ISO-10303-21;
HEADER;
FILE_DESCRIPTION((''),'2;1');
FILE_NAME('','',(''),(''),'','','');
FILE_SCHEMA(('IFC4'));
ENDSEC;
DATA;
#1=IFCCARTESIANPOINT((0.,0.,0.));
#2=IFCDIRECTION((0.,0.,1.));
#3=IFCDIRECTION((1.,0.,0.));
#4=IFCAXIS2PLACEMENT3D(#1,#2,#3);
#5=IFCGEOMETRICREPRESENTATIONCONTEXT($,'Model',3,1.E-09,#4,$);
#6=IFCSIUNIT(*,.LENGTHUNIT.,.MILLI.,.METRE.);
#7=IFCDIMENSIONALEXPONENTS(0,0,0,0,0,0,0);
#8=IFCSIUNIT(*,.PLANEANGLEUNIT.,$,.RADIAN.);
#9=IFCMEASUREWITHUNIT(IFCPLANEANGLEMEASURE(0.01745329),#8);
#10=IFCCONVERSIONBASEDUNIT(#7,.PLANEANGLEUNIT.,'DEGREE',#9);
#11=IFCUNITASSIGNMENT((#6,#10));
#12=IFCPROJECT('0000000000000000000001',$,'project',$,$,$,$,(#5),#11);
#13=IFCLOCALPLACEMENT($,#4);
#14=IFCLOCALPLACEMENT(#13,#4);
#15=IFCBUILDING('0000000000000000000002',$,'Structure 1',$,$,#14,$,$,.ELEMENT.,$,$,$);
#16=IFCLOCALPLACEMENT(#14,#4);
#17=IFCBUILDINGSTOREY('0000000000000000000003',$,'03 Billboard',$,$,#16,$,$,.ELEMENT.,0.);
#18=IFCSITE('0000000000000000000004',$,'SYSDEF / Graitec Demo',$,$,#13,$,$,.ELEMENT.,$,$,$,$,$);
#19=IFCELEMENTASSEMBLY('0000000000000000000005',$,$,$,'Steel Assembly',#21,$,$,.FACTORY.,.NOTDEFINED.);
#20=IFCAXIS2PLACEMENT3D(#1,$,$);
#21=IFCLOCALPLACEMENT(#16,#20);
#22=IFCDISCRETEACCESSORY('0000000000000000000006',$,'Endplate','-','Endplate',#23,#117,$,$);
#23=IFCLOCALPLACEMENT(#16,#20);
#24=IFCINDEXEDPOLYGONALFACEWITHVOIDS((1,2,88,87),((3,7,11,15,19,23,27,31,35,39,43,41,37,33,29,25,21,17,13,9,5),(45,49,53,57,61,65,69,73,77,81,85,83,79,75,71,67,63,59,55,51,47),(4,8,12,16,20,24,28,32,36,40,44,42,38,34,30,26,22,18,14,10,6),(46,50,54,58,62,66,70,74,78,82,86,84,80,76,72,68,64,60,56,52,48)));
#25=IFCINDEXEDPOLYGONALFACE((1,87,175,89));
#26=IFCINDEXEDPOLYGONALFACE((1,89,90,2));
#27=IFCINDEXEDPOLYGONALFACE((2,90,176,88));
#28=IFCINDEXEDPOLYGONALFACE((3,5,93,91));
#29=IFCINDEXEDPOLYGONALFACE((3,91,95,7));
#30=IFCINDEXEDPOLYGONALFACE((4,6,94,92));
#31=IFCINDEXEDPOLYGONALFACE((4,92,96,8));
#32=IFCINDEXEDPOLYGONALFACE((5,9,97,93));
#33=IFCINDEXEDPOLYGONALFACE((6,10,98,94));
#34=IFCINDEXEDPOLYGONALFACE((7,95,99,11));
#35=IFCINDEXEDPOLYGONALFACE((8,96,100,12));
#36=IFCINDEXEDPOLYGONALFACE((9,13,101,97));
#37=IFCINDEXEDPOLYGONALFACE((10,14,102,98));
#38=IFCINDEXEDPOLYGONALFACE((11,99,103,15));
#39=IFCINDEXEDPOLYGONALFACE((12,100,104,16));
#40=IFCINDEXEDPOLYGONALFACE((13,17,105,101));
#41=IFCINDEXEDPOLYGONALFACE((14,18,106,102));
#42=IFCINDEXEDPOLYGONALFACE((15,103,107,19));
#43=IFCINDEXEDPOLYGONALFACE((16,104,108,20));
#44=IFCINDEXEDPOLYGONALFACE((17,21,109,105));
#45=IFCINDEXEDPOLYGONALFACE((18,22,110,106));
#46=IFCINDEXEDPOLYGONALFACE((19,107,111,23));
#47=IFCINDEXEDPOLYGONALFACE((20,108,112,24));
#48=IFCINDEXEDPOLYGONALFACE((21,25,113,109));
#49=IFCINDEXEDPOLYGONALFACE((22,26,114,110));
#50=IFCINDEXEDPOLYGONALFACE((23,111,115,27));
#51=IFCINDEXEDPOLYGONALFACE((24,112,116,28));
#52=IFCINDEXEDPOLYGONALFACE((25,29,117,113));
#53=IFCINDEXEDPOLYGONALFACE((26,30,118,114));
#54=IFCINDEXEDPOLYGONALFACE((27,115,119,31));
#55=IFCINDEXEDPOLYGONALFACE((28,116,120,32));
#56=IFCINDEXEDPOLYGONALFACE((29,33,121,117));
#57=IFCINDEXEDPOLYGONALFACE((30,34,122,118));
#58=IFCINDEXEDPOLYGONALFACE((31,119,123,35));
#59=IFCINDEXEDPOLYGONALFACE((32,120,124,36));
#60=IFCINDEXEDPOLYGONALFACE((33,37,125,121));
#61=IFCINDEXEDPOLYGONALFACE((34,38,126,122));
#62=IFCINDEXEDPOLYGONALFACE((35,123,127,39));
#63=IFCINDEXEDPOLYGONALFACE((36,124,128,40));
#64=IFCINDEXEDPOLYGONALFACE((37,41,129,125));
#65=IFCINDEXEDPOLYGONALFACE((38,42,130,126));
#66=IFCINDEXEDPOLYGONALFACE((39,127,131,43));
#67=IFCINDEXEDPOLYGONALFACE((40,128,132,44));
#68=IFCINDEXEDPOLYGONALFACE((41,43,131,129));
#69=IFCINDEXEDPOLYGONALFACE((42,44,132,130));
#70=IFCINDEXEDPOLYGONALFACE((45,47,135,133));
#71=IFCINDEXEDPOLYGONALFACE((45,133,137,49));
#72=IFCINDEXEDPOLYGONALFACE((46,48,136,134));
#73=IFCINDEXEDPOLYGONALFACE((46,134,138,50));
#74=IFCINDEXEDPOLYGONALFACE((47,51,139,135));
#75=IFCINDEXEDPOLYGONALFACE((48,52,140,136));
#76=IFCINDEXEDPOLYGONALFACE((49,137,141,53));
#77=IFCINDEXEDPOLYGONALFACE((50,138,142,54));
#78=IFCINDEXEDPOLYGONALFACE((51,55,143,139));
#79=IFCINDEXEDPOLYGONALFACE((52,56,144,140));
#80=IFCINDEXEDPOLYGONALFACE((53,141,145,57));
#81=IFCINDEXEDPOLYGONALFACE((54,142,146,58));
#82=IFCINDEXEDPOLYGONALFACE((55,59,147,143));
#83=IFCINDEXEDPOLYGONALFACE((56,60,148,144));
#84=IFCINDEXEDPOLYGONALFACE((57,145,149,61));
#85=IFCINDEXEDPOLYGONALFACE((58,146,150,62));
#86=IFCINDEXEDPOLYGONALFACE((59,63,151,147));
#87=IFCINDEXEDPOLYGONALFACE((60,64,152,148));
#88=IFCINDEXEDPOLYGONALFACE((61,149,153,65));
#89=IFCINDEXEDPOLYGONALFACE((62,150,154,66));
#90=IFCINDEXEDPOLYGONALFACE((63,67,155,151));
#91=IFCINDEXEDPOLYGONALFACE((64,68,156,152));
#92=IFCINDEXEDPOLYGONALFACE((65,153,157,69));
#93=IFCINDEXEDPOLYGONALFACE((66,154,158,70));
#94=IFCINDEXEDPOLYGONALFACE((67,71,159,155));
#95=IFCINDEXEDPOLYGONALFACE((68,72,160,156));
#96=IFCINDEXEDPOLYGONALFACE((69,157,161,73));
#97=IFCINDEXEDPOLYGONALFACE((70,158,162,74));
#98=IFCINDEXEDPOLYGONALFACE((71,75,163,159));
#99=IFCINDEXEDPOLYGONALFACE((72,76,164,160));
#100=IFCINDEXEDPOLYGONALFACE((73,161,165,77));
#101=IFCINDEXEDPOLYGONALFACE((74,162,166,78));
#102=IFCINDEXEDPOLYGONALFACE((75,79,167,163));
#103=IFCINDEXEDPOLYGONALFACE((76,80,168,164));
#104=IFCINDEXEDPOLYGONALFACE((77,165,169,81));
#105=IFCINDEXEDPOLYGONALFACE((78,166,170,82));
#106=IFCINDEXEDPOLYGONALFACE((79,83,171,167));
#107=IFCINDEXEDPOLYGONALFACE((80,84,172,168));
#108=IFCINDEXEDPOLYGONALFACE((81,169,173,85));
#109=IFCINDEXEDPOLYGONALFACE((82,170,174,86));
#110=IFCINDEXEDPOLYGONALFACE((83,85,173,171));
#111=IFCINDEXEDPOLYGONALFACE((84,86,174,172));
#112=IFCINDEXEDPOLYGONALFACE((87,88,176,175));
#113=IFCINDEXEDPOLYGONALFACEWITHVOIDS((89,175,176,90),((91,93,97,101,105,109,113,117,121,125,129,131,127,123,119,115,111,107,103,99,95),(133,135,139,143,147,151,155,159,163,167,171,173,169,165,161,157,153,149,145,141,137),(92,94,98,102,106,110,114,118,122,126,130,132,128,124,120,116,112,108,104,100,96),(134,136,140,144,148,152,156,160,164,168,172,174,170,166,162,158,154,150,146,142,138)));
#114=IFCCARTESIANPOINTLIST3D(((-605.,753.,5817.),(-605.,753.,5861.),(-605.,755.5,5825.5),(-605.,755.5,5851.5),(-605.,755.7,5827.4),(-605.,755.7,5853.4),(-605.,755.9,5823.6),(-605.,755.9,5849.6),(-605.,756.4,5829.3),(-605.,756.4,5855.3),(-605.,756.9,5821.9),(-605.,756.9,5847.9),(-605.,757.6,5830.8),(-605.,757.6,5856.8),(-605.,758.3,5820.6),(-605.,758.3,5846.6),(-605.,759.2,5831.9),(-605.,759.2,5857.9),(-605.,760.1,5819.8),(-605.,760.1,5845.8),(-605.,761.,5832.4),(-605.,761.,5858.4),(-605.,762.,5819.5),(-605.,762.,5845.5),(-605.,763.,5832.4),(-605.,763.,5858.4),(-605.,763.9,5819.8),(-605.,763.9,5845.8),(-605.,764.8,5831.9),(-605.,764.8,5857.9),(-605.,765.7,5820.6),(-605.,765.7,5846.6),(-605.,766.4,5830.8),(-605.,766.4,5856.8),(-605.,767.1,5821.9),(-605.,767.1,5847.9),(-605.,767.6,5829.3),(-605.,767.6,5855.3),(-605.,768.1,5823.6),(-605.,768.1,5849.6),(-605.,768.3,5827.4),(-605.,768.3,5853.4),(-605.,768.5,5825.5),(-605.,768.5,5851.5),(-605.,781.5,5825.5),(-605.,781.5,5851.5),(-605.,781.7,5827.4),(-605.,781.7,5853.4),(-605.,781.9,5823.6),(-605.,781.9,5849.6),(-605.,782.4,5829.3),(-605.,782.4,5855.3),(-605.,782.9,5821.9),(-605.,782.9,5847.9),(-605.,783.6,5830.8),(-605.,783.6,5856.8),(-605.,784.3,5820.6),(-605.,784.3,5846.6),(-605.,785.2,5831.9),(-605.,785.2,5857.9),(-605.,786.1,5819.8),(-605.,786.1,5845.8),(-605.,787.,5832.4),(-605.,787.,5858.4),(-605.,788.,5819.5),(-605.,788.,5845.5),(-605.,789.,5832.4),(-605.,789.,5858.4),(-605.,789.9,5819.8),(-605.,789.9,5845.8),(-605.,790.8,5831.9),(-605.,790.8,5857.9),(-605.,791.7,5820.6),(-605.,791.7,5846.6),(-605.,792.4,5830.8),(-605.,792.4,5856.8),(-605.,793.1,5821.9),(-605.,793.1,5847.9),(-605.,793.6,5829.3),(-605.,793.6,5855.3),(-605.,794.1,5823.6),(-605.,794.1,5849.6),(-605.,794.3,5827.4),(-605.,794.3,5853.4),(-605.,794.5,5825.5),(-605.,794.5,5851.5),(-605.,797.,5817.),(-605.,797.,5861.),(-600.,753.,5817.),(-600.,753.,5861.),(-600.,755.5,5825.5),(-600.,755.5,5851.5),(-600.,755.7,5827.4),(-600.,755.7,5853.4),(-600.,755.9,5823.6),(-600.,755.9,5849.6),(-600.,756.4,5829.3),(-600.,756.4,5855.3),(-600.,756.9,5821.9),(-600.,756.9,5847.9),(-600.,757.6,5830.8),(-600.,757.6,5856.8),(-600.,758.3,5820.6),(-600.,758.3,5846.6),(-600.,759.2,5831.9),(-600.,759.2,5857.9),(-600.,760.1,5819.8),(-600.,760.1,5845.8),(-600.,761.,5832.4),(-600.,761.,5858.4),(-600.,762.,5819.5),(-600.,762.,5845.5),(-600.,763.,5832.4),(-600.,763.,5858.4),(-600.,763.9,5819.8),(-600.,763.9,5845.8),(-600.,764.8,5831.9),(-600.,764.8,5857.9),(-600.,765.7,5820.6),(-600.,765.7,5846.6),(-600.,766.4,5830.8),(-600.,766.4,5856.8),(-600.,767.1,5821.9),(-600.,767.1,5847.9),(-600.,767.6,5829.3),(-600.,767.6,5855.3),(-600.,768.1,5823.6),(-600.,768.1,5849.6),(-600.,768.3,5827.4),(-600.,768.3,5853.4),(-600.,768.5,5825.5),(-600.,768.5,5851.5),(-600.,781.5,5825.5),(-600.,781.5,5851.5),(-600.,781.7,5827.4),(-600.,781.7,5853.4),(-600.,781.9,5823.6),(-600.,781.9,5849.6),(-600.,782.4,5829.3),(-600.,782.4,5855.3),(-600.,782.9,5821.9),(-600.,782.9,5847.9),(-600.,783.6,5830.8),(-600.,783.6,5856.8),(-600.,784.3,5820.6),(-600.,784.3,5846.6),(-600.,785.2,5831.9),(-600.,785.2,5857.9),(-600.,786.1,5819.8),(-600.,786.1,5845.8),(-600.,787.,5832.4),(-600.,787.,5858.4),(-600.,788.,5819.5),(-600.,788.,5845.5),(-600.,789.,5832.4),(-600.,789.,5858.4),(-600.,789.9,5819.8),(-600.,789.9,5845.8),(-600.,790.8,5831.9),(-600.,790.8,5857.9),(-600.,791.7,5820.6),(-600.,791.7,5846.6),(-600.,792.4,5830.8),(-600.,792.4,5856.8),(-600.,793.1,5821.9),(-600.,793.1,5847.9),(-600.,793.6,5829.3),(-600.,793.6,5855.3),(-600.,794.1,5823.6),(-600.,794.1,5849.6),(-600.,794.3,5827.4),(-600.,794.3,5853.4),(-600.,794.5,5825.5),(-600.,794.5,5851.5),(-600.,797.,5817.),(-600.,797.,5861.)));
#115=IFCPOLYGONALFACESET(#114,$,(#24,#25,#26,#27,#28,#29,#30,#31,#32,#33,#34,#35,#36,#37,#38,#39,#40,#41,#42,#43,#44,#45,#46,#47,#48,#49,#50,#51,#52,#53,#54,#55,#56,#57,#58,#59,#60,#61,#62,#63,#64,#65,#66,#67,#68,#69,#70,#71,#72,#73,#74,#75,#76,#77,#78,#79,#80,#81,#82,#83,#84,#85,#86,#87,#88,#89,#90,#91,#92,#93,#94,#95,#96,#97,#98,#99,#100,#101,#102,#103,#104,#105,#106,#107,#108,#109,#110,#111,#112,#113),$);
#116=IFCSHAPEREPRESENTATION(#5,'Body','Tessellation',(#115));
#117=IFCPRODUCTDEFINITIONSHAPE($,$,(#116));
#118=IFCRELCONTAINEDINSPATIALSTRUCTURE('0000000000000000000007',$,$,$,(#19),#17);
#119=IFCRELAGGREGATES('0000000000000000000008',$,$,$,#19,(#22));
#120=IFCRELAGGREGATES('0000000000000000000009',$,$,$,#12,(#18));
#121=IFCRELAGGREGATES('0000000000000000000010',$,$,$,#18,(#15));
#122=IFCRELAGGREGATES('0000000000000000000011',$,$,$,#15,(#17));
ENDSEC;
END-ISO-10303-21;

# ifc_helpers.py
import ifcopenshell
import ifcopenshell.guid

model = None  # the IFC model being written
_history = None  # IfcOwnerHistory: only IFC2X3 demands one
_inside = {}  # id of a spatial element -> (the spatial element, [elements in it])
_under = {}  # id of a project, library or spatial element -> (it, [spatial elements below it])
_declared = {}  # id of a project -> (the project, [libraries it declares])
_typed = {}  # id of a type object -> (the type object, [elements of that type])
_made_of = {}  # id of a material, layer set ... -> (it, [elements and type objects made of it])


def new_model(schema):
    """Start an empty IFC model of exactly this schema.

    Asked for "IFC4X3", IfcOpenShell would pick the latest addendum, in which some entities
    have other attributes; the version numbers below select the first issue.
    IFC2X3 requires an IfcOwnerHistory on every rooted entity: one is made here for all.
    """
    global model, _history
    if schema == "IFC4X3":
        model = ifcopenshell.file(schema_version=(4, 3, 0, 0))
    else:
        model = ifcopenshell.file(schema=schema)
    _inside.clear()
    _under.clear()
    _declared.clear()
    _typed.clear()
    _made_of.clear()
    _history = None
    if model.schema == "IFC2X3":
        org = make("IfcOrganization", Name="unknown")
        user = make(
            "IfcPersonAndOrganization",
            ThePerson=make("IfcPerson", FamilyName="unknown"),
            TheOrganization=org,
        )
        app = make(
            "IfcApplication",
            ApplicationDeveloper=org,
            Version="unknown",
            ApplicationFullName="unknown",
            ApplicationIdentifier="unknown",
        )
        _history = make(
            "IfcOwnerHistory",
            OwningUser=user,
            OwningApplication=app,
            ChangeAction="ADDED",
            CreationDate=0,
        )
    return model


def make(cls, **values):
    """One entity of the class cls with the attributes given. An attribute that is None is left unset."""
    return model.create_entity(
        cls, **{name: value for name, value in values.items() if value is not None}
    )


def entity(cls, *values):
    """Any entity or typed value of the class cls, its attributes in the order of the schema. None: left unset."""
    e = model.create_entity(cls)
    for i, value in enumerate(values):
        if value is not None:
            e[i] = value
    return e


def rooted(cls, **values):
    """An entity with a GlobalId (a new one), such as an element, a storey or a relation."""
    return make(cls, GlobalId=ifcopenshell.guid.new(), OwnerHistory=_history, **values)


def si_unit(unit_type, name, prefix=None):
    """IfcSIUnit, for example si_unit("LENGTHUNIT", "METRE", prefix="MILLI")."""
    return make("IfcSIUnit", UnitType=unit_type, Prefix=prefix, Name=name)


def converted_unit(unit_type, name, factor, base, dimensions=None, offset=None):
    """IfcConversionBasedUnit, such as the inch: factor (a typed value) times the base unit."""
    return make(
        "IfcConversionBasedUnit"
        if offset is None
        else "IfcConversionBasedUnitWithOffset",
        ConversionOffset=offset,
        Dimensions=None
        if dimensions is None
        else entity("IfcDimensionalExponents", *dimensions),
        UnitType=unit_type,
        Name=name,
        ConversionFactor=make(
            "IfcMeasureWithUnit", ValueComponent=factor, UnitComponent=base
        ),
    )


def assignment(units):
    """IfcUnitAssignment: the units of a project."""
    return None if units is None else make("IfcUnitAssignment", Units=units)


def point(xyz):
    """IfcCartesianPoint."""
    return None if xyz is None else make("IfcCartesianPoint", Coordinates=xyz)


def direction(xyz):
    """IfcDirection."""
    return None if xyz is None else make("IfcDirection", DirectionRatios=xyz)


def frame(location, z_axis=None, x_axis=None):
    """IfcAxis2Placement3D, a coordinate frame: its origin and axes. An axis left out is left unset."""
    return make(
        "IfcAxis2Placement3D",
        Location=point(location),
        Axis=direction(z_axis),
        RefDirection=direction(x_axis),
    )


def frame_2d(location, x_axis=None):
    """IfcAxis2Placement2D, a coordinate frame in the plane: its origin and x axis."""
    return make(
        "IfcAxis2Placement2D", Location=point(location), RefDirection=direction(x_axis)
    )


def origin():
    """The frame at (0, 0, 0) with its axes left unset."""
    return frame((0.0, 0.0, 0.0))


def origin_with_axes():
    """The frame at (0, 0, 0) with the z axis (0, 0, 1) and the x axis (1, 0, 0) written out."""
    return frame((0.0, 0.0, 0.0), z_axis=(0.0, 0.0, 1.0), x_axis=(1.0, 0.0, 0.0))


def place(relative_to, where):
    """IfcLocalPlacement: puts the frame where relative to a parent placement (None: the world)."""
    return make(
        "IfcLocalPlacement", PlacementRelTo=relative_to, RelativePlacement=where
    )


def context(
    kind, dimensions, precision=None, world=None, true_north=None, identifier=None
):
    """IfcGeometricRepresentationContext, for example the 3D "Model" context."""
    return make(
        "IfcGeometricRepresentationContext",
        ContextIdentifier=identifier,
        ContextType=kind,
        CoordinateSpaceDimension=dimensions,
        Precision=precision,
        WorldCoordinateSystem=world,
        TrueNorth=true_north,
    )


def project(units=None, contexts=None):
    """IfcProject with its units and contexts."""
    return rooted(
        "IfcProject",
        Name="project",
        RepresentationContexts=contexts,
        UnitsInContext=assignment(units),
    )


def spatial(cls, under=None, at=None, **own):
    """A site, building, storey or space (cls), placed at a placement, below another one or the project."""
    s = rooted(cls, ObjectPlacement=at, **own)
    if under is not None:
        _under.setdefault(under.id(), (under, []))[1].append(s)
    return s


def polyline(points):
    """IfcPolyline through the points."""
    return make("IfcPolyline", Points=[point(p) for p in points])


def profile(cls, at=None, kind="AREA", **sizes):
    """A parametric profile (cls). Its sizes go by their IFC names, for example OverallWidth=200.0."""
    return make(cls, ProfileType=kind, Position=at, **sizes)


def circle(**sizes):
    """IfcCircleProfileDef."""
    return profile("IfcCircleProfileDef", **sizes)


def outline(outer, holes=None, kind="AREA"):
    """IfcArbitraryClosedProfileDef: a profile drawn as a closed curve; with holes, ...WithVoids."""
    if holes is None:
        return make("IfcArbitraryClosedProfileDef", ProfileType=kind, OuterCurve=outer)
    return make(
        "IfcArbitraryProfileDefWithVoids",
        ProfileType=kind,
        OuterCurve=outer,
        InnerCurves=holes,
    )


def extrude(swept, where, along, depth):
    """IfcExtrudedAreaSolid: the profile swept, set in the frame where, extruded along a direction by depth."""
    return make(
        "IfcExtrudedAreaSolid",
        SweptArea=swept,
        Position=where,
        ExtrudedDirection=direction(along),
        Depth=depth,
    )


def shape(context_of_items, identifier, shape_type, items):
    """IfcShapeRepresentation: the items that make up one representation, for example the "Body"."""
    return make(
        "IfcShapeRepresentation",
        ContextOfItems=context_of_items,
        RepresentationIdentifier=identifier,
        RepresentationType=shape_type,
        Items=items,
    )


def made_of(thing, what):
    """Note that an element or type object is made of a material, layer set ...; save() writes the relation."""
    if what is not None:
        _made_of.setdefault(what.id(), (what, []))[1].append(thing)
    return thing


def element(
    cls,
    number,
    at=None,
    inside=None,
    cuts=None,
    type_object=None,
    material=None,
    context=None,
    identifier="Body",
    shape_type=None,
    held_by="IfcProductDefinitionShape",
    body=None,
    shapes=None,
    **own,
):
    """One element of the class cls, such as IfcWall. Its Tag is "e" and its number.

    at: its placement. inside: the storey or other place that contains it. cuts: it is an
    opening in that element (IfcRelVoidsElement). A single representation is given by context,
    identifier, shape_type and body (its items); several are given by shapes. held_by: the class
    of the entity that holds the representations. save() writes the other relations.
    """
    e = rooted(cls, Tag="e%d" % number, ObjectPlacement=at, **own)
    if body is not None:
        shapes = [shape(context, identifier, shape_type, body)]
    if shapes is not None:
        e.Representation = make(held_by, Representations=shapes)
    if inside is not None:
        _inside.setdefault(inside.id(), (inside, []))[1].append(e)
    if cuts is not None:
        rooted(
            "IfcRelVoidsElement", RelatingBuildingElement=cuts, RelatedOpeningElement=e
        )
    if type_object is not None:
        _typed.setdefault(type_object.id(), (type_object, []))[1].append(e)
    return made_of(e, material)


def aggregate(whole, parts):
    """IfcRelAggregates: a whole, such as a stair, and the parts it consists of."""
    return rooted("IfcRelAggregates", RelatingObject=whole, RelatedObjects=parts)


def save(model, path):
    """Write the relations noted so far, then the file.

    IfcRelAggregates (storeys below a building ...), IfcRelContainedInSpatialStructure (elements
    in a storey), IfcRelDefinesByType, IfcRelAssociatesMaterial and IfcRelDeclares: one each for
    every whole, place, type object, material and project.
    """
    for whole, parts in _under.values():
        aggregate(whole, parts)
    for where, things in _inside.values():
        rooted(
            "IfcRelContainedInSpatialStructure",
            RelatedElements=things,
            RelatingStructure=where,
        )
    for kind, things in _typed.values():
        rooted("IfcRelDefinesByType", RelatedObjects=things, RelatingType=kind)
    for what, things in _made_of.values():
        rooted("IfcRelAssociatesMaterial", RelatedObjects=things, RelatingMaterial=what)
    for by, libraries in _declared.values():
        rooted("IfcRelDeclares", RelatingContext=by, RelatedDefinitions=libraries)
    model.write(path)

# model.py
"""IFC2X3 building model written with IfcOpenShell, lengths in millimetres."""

from ifc_helpers import new_model, entity, si_unit, converted_unit, frame, frame_2d, origin, origin_with_axes, place, context, project, spatial, polyline, circle, outline, extrude, element, aggregate, save


model = new_model("IFC2X3")

# Units and contexts
model_context = context("Model", 3, precision=1e-09, world=origin_with_axes())
ifc_project = project(units=[si_unit("LENGTHUNIT", "METRE", prefix="MILLI"), converted_unit("PLANEANGLEUNIT", "DEGREE", entity("IfcPlaneAngleMeasure", 0.01745329), si_unit("PLANEANGLEUNIT", "RADIAN"), dimensions=[0, 0, 0, 0, 0, 0, 0])], contexts=[model_context])

# Site, building, storey
site_placement = place(None, origin_with_axes())
site = spatial("IfcSite", under=ifc_project, at=site_placement, Name="SYSDEF / Graitec Demo", CompositionType="ELEMENT")
building_placement = place(site_placement, origin_with_axes())
building = spatial("IfcBuilding", under=site, at=building_placement, Name="Structure 1", CompositionType="ELEMENT")
storey_placement = place(building_placement, origin_with_axes())
storey = spatial("IfcBuildingStorey", under=building, at=storey_placement, Name="03 Billboard", CompositionType="ELEMENT", Elevation=0.0)

# Element assembly, discrete accessory, openings
assembly_1_placement = place(None, frame((-4239.1, -387.5, 4000.0), z_axis=(-1.0, 0.0, 0.0), x_axis=(0.0, 0.0, 1.0)))
assembly_1 = element("IfcElementAssembly", 1, at=assembly_1_placement, inside=storey, ObjectType="Steel Assembly", AssemblyPlace="FACTORY", PredefinedType="NOTDEFINED")
discrete_accessory_1_placement = place(assembly_1_placement, frame((1861.0, 1184.5, -3634.1), z_axis=(0.0, 0.0, -1.0), x_axis=(0.0, -1.0, 0.0)))
discrete_accessory_1 = element("IfcDiscreteAccessory", 2, at=discrete_accessory_1_placement, Name="Endplate", Description="-", ObjectType="Endplate", context=model_context, shape_type="SweptSolid", body=[
    extrude(outline(polyline([(0.0, 0.0), (44.0, 0.0), (44.0, 44.0), (0.0, 44.0), (0.0, 0.0)])), origin_with_axes(), (0.0, 0.0, 1.0), 5.0),
])
opening_1_placement = place(discrete_accessory_1_placement, frame((22.0, 22.0, 5.5), z_axis=(0.0, 0.0, -1.0), x_axis=(0.0, 1.0, 0.0)))
element("IfcOpeningElement", 3, at=opening_1_placement, cuts=discrete_accessory_1, ObjectType="Opening", context=model_context, shape_type="SweptSolid", body=[
    extrude(circle(Radius=6.5, at=frame_2d((13.0, 13.0), x_axis=(1.0, 0.0))), origin(), (0.0, 0.0, 1.0), 6.0),
])
opening_2_placement = place(discrete_accessory_1_placement, frame((22.0, 22.0, 5.5), z_axis=(0.0, 0.0, -1.0), x_axis=(0.0, 1.0, 0.0)))
element("IfcOpeningElement", 4, at=opening_2_placement, cuts=discrete_accessory_1, ObjectType="Opening", context=model_context, shape_type="SweptSolid", body=[
    extrude(circle(Radius=6.5, at=frame_2d((-13.0, 13.0), x_axis=(1.0, 0.0))), origin(), (0.0, 0.0, 1.0), 6.0),
])
opening_3_placement = place(discrete_accessory_1_placement, frame((22.0, 22.0, 5.5), z_axis=(0.0, 0.0, -1.0), x_axis=(0.0, 1.0, 0.0)))
element("IfcOpeningElement", 5, at=opening_3_placement, cuts=discrete_accessory_1, ObjectType="Opening", context=model_context, shape_type="SweptSolid", body=[
    extrude(circle(Radius=6.5, at=frame_2d((13.0, -13.0), x_axis=(1.0, 0.0))), origin(), (0.0, 0.0, 1.0), 6.0),
])
opening_4_placement = place(discrete_accessory_1_placement, frame((22.0, 22.0, 5.5), z_axis=(0.0, 0.0, -1.0), x_axis=(0.0, 1.0, 0.0)))
element("IfcOpeningElement", 6, at=opening_4_placement, cuts=discrete_accessory_1, ObjectType="Opening", context=model_context, shape_type="SweptSolid", body=[
    extrude(circle(Radius=6.5, at=frame_2d((-13.0, -13.0), x_axis=(1.0, 0.0))), origin(), (0.0, 0.0, 1.0), 6.0),
])
aggregate(assembly_1, [discrete_accessory_1])

save(model, "model.ifc")
